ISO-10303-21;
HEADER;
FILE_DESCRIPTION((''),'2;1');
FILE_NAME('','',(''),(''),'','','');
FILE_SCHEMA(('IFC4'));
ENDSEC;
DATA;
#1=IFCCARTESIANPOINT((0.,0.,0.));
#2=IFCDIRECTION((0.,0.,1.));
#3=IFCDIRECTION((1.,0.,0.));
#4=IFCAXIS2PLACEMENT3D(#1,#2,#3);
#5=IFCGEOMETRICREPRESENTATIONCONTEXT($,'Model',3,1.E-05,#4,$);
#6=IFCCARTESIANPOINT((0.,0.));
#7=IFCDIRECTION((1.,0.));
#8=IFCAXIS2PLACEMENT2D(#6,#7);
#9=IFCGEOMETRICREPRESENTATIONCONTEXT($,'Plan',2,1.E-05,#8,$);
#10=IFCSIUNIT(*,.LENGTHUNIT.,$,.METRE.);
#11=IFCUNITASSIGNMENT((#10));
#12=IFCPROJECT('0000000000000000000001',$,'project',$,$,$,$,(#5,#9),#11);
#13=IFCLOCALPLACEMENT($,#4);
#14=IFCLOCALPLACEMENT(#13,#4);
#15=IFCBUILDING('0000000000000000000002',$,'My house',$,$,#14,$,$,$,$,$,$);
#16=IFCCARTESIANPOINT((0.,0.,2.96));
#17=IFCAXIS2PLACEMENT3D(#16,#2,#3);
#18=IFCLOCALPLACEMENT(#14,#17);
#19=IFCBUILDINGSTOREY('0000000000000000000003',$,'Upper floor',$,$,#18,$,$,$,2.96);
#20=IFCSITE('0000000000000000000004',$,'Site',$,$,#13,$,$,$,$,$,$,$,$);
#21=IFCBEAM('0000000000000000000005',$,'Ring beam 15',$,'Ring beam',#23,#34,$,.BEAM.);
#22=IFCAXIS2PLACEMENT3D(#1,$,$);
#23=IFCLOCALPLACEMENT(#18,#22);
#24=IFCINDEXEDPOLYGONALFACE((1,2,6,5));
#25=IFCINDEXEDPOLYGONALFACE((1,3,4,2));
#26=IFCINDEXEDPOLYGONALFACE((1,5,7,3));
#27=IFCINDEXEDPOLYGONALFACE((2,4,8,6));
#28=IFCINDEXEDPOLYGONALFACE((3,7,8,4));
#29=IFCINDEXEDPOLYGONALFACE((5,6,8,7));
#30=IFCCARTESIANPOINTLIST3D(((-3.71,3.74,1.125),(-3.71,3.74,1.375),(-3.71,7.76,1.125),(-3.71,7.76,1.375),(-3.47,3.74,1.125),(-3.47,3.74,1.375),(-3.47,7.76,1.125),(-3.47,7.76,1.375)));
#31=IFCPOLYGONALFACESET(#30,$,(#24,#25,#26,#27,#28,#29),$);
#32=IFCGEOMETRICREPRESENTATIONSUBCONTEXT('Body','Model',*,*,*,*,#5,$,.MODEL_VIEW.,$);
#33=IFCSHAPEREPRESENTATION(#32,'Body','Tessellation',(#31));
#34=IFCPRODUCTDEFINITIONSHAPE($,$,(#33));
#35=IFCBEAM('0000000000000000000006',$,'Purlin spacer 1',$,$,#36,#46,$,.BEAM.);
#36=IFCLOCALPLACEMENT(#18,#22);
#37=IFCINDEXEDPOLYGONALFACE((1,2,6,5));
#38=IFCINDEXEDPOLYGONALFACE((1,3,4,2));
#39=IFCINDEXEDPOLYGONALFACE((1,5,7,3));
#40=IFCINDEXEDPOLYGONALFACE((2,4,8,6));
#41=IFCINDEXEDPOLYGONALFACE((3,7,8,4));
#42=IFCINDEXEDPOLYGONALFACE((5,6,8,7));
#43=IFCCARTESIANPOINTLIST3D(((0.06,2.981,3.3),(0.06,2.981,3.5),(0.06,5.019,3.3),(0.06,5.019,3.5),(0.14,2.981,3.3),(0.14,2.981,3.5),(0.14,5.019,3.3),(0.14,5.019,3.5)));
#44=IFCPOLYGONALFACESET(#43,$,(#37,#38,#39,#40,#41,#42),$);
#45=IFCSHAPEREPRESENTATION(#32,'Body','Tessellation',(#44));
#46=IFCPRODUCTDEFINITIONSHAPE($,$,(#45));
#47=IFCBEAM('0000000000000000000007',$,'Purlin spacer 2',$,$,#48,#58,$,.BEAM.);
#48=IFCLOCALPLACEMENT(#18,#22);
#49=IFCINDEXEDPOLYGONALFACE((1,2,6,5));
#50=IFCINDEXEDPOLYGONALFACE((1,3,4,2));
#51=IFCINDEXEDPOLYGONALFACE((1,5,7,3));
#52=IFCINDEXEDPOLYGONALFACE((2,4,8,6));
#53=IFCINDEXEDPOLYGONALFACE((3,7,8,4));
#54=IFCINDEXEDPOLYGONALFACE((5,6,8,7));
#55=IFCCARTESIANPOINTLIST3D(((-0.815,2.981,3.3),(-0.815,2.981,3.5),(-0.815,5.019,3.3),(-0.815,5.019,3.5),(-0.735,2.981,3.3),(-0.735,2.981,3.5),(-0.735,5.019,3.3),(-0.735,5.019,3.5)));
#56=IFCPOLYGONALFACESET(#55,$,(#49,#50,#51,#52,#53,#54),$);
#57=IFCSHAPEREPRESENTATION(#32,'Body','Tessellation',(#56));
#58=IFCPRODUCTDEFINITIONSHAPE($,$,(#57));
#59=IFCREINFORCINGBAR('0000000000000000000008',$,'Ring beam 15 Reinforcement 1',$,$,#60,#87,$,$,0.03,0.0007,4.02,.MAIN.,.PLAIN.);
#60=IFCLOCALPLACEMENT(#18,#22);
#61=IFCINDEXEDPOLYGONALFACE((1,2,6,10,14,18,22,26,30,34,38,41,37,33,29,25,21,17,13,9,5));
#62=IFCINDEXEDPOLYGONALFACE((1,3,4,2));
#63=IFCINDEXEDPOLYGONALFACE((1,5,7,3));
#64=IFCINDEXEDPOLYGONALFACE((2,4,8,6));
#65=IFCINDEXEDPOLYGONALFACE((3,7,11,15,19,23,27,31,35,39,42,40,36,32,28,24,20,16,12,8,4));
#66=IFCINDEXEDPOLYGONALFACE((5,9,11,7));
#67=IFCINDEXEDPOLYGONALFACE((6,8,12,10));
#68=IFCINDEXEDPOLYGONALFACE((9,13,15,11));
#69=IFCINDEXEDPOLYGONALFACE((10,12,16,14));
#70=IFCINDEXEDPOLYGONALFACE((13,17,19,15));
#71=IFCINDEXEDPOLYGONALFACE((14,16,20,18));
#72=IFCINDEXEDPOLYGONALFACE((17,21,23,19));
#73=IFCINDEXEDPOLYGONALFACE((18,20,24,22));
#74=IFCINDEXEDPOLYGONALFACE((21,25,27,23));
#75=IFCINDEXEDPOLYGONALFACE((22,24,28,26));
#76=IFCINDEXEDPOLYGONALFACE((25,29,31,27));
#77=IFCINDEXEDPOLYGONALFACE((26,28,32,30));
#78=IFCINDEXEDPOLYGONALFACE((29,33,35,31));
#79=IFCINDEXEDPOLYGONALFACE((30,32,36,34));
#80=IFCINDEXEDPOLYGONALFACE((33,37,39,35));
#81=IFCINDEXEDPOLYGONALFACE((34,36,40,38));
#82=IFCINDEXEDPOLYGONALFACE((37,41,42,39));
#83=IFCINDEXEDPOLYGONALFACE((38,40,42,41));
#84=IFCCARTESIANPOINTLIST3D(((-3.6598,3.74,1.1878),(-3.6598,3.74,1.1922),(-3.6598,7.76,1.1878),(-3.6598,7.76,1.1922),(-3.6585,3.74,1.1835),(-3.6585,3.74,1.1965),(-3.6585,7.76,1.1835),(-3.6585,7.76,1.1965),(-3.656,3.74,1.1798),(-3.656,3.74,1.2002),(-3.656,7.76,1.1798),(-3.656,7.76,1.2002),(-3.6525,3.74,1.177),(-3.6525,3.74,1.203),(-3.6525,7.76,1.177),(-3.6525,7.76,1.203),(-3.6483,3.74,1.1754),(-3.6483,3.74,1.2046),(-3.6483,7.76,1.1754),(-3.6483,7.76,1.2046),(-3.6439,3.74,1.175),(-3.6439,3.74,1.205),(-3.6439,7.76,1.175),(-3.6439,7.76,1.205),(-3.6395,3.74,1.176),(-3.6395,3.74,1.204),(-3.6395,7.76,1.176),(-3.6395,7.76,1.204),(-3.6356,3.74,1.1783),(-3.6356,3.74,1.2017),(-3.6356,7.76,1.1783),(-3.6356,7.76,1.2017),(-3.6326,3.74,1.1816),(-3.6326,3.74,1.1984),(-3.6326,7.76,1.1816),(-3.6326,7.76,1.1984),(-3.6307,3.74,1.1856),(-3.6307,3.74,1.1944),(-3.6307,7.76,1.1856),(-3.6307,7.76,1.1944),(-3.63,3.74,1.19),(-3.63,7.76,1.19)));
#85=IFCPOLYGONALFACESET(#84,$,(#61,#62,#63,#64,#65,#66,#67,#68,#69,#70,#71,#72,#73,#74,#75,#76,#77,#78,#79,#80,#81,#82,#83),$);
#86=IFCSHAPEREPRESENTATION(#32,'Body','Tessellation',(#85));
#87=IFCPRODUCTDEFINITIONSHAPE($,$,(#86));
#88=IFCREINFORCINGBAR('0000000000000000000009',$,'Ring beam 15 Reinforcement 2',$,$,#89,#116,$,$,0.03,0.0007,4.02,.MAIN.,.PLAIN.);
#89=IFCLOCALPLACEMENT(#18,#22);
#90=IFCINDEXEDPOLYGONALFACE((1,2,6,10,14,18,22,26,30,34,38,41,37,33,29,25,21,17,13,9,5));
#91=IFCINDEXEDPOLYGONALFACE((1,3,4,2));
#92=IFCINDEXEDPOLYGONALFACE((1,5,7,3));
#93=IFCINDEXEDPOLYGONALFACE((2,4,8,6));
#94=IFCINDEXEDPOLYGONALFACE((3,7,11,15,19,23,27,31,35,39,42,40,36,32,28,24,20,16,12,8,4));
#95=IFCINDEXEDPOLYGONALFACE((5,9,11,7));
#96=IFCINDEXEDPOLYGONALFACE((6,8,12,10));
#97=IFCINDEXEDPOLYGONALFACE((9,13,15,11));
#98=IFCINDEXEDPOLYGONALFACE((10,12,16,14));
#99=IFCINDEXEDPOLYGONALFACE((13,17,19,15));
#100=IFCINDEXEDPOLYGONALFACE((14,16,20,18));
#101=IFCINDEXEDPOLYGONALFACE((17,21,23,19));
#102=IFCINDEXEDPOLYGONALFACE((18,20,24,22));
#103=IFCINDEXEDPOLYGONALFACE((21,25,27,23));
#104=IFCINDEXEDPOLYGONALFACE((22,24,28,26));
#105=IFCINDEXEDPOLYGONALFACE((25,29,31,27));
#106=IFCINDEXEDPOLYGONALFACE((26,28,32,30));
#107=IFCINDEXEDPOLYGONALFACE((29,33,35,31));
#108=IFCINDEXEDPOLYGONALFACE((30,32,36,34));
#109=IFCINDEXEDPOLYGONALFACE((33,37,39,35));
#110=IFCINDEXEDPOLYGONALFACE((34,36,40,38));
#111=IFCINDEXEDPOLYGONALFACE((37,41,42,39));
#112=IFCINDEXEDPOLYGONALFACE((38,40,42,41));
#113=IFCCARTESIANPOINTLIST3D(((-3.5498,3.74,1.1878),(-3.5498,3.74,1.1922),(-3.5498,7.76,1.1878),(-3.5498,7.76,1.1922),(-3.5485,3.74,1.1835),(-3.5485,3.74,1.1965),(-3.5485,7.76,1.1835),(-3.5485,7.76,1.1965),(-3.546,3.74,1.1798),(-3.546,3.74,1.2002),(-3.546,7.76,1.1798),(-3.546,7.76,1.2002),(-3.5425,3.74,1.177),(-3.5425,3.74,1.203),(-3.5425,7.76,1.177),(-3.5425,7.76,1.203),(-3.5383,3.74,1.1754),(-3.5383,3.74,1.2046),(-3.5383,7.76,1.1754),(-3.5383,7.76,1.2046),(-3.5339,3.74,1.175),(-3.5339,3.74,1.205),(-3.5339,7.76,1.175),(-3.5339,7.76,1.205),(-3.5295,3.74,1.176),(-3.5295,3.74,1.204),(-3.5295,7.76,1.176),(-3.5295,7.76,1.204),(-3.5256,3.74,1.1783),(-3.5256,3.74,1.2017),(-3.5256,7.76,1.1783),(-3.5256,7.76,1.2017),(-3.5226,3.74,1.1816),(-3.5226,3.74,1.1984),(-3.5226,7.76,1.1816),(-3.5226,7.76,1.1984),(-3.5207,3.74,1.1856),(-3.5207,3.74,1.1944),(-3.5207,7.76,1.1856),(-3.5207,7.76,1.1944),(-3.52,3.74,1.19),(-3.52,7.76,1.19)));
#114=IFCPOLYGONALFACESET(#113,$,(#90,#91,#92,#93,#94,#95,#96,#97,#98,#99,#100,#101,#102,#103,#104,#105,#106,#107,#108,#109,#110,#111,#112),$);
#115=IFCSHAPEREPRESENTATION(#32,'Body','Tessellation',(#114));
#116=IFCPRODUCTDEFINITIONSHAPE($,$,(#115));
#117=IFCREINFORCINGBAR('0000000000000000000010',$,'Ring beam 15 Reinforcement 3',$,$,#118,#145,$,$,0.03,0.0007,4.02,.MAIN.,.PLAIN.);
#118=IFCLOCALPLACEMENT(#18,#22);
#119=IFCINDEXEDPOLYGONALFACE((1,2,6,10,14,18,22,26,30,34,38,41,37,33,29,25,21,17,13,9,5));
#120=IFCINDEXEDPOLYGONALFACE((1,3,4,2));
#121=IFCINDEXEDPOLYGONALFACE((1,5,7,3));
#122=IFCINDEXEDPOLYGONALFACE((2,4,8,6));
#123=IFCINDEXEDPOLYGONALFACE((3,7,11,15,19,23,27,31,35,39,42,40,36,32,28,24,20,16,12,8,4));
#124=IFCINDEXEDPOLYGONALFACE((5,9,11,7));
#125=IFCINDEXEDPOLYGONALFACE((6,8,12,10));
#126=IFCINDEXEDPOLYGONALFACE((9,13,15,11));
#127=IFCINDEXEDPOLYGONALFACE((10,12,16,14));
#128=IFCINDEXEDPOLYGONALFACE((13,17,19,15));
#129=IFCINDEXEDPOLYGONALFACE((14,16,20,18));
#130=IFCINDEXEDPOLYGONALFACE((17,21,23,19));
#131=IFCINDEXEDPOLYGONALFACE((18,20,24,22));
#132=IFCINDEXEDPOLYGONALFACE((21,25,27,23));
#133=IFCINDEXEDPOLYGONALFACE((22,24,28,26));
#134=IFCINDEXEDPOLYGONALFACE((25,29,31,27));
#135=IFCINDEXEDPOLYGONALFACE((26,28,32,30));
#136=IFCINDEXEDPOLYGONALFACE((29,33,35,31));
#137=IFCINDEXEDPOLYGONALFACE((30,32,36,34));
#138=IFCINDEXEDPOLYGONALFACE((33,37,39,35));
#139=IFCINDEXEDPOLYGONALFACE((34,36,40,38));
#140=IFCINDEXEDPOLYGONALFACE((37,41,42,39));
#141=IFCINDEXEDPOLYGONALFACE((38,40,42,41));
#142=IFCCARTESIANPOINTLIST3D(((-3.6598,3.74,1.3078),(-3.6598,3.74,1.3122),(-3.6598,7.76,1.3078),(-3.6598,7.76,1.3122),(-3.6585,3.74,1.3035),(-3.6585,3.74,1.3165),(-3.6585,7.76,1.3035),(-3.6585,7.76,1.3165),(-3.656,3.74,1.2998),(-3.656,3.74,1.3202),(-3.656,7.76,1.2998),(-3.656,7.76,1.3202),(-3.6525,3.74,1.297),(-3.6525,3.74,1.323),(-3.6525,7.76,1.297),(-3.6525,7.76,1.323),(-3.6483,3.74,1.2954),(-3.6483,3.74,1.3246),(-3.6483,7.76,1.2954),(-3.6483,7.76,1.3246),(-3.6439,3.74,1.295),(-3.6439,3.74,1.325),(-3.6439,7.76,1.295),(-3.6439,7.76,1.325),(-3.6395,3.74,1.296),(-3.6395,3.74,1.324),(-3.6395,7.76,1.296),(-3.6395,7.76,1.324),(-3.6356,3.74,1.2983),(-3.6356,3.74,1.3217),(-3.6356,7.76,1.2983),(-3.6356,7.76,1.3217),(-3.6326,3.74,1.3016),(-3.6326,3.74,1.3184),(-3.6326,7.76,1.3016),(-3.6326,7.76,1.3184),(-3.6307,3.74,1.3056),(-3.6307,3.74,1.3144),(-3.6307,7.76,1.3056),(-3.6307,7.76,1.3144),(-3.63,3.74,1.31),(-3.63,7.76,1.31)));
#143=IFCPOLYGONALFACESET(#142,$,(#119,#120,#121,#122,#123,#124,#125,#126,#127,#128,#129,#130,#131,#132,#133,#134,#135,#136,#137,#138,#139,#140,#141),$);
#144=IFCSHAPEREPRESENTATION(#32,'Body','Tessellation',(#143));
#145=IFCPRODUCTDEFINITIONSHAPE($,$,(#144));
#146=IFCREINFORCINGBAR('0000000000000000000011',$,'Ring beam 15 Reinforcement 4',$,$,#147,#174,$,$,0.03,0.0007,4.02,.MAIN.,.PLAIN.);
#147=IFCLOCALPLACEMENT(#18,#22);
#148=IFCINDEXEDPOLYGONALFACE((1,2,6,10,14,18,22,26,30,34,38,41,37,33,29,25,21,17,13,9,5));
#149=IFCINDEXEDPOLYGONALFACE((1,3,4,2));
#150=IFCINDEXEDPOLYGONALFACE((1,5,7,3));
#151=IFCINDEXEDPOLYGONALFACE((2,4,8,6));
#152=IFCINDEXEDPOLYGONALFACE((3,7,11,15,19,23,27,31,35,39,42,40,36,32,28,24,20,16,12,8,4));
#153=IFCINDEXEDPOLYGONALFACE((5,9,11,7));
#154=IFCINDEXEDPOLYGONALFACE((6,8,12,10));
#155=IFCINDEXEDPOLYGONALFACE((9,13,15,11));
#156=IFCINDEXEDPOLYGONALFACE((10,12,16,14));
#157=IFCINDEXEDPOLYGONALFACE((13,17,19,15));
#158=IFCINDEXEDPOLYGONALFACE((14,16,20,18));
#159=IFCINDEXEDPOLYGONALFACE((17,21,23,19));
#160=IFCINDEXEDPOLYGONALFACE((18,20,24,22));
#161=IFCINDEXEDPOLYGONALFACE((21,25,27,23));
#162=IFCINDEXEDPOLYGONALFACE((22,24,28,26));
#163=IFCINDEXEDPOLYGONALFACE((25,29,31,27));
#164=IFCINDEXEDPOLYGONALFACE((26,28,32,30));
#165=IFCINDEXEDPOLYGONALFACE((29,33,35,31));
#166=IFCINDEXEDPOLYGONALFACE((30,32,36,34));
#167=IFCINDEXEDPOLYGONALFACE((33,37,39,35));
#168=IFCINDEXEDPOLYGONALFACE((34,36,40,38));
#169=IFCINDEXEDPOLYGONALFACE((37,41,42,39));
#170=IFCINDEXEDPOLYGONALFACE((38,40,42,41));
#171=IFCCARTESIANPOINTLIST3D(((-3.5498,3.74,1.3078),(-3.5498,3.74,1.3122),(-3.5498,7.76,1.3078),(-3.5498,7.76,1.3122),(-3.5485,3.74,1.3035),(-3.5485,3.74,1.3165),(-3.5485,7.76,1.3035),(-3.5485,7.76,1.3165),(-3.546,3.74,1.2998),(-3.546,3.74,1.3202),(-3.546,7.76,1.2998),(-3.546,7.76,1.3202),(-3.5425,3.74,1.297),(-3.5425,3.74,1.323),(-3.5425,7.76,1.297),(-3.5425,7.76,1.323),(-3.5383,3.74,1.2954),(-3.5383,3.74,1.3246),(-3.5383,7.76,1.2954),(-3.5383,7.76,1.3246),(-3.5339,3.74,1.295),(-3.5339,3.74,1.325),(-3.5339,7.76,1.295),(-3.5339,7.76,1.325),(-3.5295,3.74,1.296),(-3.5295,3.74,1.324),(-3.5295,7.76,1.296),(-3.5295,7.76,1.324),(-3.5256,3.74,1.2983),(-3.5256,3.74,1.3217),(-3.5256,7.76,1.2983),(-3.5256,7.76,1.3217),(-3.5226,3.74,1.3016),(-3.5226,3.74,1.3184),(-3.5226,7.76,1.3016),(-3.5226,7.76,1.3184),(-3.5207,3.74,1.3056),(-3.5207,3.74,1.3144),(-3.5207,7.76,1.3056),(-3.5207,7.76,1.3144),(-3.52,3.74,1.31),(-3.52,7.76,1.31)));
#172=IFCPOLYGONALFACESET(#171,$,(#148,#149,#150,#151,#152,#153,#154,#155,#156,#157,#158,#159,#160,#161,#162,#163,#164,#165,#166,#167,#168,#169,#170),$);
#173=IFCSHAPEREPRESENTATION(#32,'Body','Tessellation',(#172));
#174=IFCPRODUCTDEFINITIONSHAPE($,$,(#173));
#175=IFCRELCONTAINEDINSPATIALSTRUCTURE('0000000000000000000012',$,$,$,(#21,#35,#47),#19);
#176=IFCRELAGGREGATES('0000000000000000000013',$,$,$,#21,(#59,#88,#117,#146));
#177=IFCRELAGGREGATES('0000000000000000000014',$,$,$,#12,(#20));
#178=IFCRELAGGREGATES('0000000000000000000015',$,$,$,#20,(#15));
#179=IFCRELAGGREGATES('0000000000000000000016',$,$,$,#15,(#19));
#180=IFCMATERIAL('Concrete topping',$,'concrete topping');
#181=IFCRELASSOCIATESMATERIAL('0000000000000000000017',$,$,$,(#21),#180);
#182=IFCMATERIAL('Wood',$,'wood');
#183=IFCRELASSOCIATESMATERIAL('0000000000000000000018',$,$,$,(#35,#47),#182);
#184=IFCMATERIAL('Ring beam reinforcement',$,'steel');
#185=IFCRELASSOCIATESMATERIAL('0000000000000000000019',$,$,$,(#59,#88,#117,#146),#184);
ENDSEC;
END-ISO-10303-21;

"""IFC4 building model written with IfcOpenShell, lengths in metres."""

from ifc_helpers import new_model, si_unit, frame, origin_with_axes, origin_2d, origin_2d_with_axis, place, context, subcontext, project, spatial, circle_curve, rectangle, outline, extrude, source, transform, mapped, material, element, aggregate, save


model = new_model("IFC4")

# Units and contexts
model_context = context("Model", 3, precision=1e-05, world=origin_with_axes())
plan_context = context("Plan", 2, precision=1e-05, world=origin_2d_with_axis())
body_context_1 = subcontext(model_context, "Body", "Model", "MODEL_VIEW")
ifc_project = project(units=[si_unit("LENGTHUNIT", "METRE")], contexts=[model_context, plan_context])

# Site, building, storey
site_placement = place(None, origin_with_axes())
site = spatial("IfcSite", under=ifc_project, at=site_placement, Name="Site")
building_placement = place(site_placement, origin_with_axes())
building = spatial("IfcBuilding", under=site, at=building_placement, Name="My house")
storey_placement = place(building_placement, frame((0.0, 0.0, 2.96), z_axis=(0.0, 0.0, 1.0), x_axis=(1.0, 0.0, 0.0)))
storey = spatial("IfcBuildingStorey", under=building, at=storey_placement, Name="Upper floor", Elevation=2.96)

# Shared definitions
ifc_material_1 = material(Name="Concrete topping", Category="concrete topping")

# Shared definitions
ifc_material_2 = material(Name="Wood", Category="wood")

# Beam
shared_shape_1 = source(origin_with_axes(), body_context_1, "Body", "SweptSolid", [
    extrude(rectangle(XDim=0.24, YDim=0.25), frame((0.0, 0.0, 0.0), z_axis=(1.0, 0.0, 0.0), x_axis=(0.0, 1.0, 0.0)), (0.0, 0.0, 1.0), 4.02),
])
beam_1_placement = place(storey_placement, frame((-3.59, 3.74, 1.25), z_axis=(0.0, 0.0, 1.0), x_axis=(0.0, -1.0, 0.0)))
beam_1 = element("IfcBeam", 1, at=beam_1_placement, inside=storey, material=ifc_material_1, Name="Ring beam 15", ObjectType="Ring beam", PredefinedType="BEAM", context=body_context_1, shape_type="MappedRepresentation", body=[
    mapped(shared_shape_1, transform((0.0, 0.0, 0.0), x_axis=(-1.0, 0.0, 0.0), y_axis=(0.0, 1.0, 0.0), z_axis=(0.0, 0.0, 1.0), scale=1.0)),
])

# Beams
shared_shape_2 = source(origin_with_axes(), body_context_1, "Body", "SweptSolid", [
    extrude(rectangle(XDim=0.08, YDim=0.2), frame((0.0, 0.0, 0.0), z_axis=(1.0, 0.0, 0.0), x_axis=(0.0, 1.0, 0.0)), (0.0, 0.0, 1.0), 2.038),
])
beam_2_placement = place(storey_placement, frame((0.1, 2.981, 3.4), z_axis=(0.0, 0.0, 1.0), x_axis=(0.0, -1.0, 0.0)))
element("IfcBeam", 2, at=beam_2_placement, inside=storey, material=ifc_material_2, Name="Purlin spacer 1", PredefinedType="BEAM", context=body_context_1, shape_type="MappedRepresentation", body=[
    mapped(shared_shape_2, transform((0.0, 0.0, 0.0), x_axis=(-1.0, 0.0, 0.0), y_axis=(0.0, 1.0, 0.0), z_axis=(0.0, 0.0, 1.0), scale=1.0)),
])
shared_shape_3 = source(origin_with_axes(), body_context_1, "Body", "SweptSolid", [
    extrude(rectangle(XDim=0.08, YDim=0.2), frame((0.0, 0.0, 0.0), z_axis=(1.0, 0.0, 0.0), x_axis=(0.0, 1.0, 0.0)), (0.0, 0.0, 1.0), 2.038),
])
beam_3_placement = place(storey_placement, frame((-0.775, 2.981, 3.4), z_axis=(0.0, 0.0, 1.0), x_axis=(0.0, -1.0, 0.0)))
element("IfcBeam", 3, at=beam_3_placement, inside=storey, material=ifc_material_2, Name="Purlin spacer 2", PredefinedType="BEAM", context=body_context_1, shape_type="MappedRepresentation", body=[
    mapped(shared_shape_3, transform((0.0, 0.0, 0.0), x_axis=(-1.0, 0.0, 0.0), y_axis=(0.0, 1.0, 0.0), z_axis=(0.0, 0.0, 1.0), scale=1.0)),
])

# Reinforcing bars
ifc_material_3 = material(Name="Ring beam reinforcement", Category="steel")
shared_shape_4 = source(origin_with_axes(), body_context_1, "Body", "SweptSolid", [
    extrude(outline(circle_curve(origin_2d(), 0.015)), frame((0.0, 0.0, 0.0), z_axis=(1.0, 0.0, 0.0), x_axis=(0.0, 1.0, 0.0)), (0.0, 0.0, 1.0), 4.02),
])
reinforcing_bar_1_placement = place(beam_1_placement, frame((0.0, -0.055, -0.06), z_axis=(0.0, 0.0, 1.0), x_axis=(1.0, 0.0, 0.0)))
reinforcing_bar_1 = element("IfcReinforcingBar", 4, at=reinforcing_bar_1_placement, material=ifc_material_3, Name="Ring beam 15 Reinforcement 1", BarLength=4.02, BarSurface="PLAIN", CrossSectionArea=0.0007, NominalDiameter=0.03, PredefinedType="MAIN", context=body_context_1, shape_type="MappedRepresentation", body=[
    mapped(shared_shape_4, transform((0.0, 0.0, 0.0), x_axis=(-1.0, 0.0, 0.0), y_axis=(0.0, 1.0, 0.0), z_axis=(0.0, 0.0, 1.0), scale=1.0)),
])
shared_shape_5 = source(origin_with_axes(), body_context_1, "Body", "SweptSolid", [
    extrude(outline(circle_curve(origin_2d(), 0.015)), frame((0.0, 0.0, 0.0), z_axis=(1.0, 0.0, 0.0), x_axis=(0.0, 1.0, 0.0)), (0.0, 0.0, 1.0), 4.02),
])
reinforcing_bar_2_placement = place(beam_1_placement, frame((0.0, 0.055, -0.06), z_axis=(0.0, 0.0, 1.0), x_axis=(1.0, 0.0, 0.0)))
reinforcing_bar_2 = element("IfcReinforcingBar", 5, at=reinforcing_bar_2_placement, material=ifc_material_3, Name="Ring beam 15 Reinforcement 2", BarLength=4.02, BarSurface="PLAIN", CrossSectionArea=0.0007, NominalDiameter=0.03, PredefinedType="MAIN", context=body_context_1, shape_type="MappedRepresentation", body=[
    mapped(shared_shape_5, transform((0.0, 0.0, 0.0), x_axis=(-1.0, 0.0, 0.0), y_axis=(0.0, 1.0, 0.0), z_axis=(0.0, 0.0, 1.0), scale=1.0)),
])
shared_shape_6 = source(origin_with_axes(), body_context_1, "Body", "SweptSolid", [
    extrude(outline(circle_curve(origin_2d(), 0.015)), frame((0.0, 0.0, 0.0), z_axis=(1.0, 0.0, 0.0), x_axis=(0.0, 1.0, 0.0)), (0.0, 0.0, 1.0), 4.02),
])
reinforcing_bar_3_placement = place(beam_1_placement, frame((0.0, -0.055, 0.06), z_axis=(0.0, 0.0, 1.0), x_axis=(1.0, 0.0, 0.0)))
reinforcing_bar_3 = element("IfcReinforcingBar", 6, at=reinforcing_bar_3_placement, material=ifc_material_3, Name="Ring beam 15 Reinforcement 3", BarLength=4.02, BarSurface="PLAIN", CrossSectionArea=0.0007, NominalDiameter=0.03, PredefinedType="MAIN", context=body_context_1, shape_type="MappedRepresentation", body=[
    mapped(shared_shape_6, transform((0.0, 0.0, 0.0), x_axis=(-1.0, 0.0, 0.0), y_axis=(0.0, 1.0, 0.0), z_axis=(0.0, 0.0, 1.0), scale=1.0)),
])
shared_shape_7 = source(origin_with_axes(), body_context_1, "Body", "SweptSolid", [
    extrude(outline(circle_curve(origin_2d(), 0.015)), frame((0.0, 0.0, 0.0), z_axis=(1.0, 0.0, 0.0), x_axis=(0.0, 1.0, 0.0)), (0.0, 0.0, 1.0), 4.02),
])
reinforcing_bar_4_placement = place(beam_1_placement, frame((0.0, 0.055, 0.06), z_axis=(0.0, 0.0, 1.0), x_axis=(1.0, 0.0, 0.0)))
reinforcing_bar_4 = element("IfcReinforcingBar", 7, at=reinforcing_bar_4_placement, material=ifc_material_3, Name="Ring beam 15 Reinforcement 4", BarLength=4.02, BarSurface="PLAIN", CrossSectionArea=0.0007, NominalDiameter=0.03, PredefinedType="MAIN", context=body_context_1, shape_type="MappedRepresentation", body=[
    mapped(shared_shape_7, transform((0.0, 0.0, 0.0), x_axis=(-1.0, 0.0, 0.0), y_axis=(0.0, 1.0, 0.0), z_axis=(0.0, 0.0, 1.0), scale=1.0)),
])
aggregate(beam_1, [reinforcing_bar_1, reinforcing_bar_2, reinforcing_bar_3, reinforcing_bar_4])

save(model, "model.ifc")
